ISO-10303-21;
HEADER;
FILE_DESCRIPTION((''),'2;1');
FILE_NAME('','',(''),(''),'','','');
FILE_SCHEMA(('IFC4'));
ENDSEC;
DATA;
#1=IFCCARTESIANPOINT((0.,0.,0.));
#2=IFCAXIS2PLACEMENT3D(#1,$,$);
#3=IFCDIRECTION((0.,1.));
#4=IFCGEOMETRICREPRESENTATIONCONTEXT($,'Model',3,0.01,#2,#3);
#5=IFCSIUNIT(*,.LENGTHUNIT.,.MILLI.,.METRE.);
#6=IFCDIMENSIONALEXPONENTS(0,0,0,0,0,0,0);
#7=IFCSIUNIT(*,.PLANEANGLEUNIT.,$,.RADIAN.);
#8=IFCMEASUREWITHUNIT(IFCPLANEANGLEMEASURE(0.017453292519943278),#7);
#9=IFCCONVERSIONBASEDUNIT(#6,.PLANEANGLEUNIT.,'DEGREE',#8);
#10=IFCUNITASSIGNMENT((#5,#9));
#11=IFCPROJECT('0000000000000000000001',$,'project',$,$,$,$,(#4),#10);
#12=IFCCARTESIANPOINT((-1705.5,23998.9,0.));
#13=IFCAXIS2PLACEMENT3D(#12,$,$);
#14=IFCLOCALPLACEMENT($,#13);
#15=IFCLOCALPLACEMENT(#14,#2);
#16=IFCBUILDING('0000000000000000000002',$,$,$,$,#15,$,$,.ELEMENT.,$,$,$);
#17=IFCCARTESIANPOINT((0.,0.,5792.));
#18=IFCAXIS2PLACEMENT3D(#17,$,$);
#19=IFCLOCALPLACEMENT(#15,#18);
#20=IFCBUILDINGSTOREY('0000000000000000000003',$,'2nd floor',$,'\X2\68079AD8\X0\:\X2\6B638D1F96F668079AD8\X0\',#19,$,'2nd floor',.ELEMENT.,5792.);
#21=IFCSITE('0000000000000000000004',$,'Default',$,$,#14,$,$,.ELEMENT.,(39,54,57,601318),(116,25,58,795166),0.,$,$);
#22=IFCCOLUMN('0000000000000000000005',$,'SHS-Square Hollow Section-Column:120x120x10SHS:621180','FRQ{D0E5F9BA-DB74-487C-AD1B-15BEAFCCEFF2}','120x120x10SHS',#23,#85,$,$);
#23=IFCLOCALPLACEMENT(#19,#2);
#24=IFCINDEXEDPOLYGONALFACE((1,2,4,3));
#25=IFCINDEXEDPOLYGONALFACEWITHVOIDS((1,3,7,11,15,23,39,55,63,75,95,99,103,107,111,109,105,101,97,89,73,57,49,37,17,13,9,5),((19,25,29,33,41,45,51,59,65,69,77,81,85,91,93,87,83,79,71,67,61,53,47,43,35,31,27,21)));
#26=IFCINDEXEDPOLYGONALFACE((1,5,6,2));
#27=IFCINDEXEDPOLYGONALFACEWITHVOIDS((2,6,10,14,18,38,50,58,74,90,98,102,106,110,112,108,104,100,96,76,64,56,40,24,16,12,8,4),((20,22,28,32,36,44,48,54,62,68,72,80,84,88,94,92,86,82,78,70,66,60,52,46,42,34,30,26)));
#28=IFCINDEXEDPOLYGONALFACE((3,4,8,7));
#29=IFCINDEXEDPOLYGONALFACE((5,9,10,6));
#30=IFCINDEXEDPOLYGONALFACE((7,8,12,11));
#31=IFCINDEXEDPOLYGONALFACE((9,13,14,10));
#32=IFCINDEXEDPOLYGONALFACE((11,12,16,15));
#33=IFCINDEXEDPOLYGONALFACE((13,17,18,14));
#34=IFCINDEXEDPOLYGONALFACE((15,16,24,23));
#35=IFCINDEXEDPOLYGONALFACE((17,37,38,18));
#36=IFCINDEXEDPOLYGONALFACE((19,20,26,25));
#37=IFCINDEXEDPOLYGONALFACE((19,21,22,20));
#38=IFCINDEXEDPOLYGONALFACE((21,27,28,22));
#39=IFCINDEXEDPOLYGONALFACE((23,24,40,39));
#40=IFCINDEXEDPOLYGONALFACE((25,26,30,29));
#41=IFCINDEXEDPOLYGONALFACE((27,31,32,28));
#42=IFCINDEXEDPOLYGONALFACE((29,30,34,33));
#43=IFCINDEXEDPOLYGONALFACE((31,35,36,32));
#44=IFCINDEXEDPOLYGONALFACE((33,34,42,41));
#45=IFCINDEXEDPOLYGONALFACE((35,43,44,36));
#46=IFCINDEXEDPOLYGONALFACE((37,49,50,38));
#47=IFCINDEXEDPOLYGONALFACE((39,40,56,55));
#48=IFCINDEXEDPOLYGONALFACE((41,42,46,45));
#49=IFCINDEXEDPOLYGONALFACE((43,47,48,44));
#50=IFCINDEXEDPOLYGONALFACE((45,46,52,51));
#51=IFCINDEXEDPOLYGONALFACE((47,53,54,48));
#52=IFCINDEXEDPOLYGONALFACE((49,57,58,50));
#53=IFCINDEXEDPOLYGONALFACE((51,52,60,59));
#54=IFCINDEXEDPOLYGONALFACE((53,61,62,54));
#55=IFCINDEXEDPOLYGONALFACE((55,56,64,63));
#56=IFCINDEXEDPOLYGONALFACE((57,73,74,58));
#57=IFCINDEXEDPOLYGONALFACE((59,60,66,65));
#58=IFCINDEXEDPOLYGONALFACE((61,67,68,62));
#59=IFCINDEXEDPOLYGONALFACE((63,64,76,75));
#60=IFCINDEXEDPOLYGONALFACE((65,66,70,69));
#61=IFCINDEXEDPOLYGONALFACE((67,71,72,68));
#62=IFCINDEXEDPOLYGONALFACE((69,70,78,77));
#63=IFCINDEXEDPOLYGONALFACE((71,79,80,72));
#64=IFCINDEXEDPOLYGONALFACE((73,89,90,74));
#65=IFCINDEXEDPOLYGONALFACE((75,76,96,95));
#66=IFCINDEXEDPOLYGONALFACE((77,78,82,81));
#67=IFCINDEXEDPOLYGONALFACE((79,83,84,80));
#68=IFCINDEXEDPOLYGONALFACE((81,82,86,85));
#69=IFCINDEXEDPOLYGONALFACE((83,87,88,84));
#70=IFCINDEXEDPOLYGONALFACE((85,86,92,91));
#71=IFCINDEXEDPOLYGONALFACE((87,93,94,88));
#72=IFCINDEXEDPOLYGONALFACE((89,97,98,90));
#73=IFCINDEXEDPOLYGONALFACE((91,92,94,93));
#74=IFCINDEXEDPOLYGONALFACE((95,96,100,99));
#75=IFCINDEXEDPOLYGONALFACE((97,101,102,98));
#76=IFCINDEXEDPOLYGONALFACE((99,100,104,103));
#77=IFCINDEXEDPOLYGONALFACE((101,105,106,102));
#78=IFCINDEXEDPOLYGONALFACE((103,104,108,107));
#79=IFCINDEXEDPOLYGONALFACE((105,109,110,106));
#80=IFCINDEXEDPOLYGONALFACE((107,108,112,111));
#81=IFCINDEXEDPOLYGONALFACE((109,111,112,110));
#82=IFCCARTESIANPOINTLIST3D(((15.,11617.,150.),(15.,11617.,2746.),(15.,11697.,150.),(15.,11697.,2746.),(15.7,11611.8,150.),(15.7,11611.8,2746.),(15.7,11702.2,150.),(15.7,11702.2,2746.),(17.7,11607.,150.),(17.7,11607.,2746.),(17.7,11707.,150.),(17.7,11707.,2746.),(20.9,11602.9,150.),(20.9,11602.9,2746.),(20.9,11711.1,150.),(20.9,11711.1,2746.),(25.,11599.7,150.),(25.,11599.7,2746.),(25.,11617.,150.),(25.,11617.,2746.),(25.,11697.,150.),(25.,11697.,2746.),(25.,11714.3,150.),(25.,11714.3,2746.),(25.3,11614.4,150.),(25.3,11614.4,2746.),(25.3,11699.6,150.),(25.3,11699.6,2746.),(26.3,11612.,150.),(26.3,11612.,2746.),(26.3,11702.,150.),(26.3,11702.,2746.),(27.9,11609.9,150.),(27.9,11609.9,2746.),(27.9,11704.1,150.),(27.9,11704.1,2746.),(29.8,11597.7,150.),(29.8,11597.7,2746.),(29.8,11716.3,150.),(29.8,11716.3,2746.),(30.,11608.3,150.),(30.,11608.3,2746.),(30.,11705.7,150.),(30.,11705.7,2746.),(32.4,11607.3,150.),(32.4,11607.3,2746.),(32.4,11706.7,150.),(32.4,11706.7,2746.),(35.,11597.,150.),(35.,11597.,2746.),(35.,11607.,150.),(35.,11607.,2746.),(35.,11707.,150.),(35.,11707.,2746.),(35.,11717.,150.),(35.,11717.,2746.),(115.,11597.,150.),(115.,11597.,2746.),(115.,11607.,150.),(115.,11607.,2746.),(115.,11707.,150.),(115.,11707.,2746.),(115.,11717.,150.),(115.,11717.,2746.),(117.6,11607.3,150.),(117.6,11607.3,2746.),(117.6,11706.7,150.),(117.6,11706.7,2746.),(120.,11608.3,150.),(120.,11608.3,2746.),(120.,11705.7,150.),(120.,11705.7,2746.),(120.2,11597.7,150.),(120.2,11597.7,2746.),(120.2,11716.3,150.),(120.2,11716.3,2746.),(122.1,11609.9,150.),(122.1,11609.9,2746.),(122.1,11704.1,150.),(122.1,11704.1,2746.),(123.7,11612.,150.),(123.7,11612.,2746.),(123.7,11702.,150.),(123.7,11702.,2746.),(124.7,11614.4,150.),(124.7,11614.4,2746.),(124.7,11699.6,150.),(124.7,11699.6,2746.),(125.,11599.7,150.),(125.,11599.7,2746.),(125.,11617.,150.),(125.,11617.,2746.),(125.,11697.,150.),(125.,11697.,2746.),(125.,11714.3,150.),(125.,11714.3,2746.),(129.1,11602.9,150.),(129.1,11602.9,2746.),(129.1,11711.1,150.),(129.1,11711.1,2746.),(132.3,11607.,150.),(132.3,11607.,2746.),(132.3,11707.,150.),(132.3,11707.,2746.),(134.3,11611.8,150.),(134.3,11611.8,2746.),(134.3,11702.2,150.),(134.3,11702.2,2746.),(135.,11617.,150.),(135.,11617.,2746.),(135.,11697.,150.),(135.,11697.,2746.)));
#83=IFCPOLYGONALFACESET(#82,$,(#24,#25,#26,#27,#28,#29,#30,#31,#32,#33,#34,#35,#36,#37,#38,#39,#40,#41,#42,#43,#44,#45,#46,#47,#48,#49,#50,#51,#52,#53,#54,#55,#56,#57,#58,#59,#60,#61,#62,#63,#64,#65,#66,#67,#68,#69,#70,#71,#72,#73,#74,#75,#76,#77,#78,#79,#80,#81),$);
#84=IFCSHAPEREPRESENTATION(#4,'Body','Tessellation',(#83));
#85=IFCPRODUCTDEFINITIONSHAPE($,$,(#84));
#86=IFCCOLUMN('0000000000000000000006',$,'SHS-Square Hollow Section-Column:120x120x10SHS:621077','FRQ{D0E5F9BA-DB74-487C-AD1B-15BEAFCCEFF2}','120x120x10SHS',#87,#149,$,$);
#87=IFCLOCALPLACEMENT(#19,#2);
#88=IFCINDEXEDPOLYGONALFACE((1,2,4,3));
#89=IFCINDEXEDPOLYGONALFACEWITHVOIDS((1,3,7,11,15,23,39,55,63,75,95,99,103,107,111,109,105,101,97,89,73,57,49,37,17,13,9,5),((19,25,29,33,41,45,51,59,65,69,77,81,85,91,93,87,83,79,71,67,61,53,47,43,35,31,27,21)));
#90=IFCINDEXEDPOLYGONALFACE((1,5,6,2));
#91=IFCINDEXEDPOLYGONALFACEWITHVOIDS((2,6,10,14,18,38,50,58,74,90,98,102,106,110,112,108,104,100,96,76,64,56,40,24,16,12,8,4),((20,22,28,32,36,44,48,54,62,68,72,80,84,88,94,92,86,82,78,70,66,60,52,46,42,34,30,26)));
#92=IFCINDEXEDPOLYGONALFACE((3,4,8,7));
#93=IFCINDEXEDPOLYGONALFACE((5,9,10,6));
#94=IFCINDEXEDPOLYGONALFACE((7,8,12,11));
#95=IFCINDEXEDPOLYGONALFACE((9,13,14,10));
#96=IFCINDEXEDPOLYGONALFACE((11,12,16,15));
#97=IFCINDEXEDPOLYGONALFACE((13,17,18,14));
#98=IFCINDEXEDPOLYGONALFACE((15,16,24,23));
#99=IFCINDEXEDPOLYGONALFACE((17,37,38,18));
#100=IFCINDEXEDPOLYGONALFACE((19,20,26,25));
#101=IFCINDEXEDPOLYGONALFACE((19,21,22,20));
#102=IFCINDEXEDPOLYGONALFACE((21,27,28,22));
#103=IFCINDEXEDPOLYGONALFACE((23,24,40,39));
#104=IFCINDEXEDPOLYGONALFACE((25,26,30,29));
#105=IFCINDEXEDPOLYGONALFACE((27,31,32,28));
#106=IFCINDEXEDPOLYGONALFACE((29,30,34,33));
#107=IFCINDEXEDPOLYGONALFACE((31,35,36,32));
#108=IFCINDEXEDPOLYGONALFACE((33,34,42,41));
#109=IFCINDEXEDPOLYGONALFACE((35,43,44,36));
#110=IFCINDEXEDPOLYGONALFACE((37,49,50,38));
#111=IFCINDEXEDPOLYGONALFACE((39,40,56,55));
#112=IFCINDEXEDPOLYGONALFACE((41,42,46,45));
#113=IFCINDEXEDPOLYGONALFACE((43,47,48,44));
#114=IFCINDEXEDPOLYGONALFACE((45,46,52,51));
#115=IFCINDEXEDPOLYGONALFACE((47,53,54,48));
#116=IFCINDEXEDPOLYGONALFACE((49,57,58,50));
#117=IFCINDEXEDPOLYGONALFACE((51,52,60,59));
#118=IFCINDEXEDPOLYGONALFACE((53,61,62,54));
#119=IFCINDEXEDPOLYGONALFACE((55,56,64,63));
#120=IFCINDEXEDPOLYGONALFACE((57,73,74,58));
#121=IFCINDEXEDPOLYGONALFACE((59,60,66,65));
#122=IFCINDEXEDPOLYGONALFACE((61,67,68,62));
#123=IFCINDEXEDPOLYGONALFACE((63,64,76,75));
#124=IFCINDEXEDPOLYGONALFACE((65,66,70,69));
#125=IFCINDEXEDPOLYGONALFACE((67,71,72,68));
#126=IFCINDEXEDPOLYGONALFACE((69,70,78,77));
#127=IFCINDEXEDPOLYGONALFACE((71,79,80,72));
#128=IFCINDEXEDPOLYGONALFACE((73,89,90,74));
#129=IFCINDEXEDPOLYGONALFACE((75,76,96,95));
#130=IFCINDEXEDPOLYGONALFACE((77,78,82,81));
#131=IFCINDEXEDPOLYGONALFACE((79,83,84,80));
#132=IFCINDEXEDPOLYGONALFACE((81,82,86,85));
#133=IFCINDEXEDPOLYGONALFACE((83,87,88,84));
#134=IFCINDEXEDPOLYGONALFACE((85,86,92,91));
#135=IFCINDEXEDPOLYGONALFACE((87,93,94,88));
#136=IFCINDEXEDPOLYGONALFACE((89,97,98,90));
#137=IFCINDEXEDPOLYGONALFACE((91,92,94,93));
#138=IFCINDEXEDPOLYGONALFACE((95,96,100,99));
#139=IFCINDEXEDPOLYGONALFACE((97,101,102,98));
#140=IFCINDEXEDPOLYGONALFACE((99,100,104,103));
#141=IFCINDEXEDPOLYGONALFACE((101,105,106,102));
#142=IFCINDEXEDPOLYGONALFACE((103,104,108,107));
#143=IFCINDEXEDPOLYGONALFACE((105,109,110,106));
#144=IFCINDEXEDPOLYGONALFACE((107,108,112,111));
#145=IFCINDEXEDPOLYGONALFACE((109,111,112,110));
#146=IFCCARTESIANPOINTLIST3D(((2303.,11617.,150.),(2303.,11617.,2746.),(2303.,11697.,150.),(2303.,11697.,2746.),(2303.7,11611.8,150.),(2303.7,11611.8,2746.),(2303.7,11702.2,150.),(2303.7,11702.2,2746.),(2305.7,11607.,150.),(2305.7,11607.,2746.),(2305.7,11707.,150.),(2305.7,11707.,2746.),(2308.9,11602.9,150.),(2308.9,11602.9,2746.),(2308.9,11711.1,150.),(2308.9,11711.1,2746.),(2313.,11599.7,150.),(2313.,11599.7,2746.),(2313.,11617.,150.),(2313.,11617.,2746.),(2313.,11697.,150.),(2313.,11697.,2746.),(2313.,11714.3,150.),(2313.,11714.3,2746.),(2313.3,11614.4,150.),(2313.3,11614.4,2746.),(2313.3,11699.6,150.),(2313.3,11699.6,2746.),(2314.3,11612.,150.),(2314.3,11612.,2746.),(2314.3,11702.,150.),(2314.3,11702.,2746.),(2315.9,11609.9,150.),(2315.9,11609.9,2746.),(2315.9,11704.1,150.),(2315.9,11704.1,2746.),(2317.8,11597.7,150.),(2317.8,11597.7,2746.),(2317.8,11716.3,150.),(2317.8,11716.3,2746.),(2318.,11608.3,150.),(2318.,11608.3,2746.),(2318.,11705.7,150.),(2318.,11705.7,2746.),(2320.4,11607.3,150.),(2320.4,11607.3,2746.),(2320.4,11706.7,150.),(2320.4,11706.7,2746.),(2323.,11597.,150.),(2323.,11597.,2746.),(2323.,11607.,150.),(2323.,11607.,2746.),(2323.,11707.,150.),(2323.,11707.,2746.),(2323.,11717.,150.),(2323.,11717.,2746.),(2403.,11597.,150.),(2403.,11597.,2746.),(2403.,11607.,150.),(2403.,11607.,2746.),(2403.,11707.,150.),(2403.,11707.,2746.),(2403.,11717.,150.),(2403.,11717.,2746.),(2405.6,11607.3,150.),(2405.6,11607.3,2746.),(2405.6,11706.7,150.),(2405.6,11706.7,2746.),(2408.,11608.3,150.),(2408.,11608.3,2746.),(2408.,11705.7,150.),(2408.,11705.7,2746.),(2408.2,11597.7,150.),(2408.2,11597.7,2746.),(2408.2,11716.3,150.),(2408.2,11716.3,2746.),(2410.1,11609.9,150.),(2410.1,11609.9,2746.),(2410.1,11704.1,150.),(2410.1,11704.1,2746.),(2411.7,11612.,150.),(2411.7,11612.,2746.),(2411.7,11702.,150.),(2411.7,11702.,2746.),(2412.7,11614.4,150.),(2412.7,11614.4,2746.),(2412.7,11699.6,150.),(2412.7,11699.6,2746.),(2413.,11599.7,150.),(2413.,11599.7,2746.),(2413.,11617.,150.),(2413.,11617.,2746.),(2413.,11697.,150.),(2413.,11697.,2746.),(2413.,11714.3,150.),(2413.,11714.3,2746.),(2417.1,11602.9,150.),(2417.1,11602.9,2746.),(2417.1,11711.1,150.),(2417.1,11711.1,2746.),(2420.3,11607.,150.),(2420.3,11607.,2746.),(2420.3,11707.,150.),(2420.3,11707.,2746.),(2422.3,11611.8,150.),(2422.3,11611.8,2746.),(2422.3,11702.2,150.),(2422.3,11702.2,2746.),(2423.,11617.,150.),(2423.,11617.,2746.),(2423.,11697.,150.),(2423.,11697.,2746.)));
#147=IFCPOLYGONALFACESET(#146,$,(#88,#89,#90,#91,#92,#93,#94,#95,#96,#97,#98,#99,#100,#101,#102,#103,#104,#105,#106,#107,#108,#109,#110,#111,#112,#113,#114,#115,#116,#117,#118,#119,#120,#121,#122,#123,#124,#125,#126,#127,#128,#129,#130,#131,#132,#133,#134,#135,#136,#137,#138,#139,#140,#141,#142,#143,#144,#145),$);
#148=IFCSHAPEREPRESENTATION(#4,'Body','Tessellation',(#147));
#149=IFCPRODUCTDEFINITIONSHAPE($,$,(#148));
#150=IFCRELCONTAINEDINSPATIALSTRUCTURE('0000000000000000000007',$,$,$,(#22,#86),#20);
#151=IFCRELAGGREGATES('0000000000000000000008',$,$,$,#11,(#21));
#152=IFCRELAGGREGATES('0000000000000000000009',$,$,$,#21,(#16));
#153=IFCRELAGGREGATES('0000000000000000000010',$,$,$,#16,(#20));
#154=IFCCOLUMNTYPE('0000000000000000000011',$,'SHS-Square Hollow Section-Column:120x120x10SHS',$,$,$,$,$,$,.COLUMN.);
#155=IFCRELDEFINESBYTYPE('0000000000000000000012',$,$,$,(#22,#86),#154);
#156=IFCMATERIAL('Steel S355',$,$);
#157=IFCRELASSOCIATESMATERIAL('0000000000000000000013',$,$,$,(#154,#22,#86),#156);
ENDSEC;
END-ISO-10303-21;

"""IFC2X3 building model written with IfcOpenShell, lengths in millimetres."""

from ifc_helpers import new_model, entity, si_unit, converted_unit, direction, frame, origin, origin_2d, place, context, project, spatial, hollow_rectangle, extrude, clip, halfspace, material, type_object, element, save


model = new_model("IFC2X3")

# Units and contexts
model_context = context("Model", 3, precision=0.01, world=origin(), true_north=direction((0.0, 1.0)))
ifc_project = project(units=[si_unit("LENGTHUNIT", "METRE", prefix="MILLI"), converted_unit("PLANEANGLEUNIT", "DEGREE", entity("IfcPlaneAngleMeasure", 0.017453292519943278), si_unit("PLANEANGLEUNIT", "RADIAN"), dimensions=[0, 0, 0, 0, 0, 0, 0])], contexts=[model_context])

# Site, building, storey
site_placement = place(None, frame((-1705.5, 23998.9, 0.0)))
site = spatial("IfcSite", under=ifc_project, at=site_placement, Name="Default", CompositionType="ELEMENT", RefLatitude=(39, 54, 57, 601318), RefLongitude=(116, 25, 58, 795166), RefElevation=0.0)
building_placement = place(site_placement, origin())
building = spatial("IfcBuilding", under=site, at=building_placement, CompositionType="ELEMENT")
storey_placement = place(building_placement, frame((0.0, 0.0, 5792.0)))
storey = spatial("IfcBuildingStorey", under=building, at=storey_placement, Name="2nd floor", ObjectType="标高:正负零标高", LongName="2nd floor", CompositionType="ELEMENT", Elevation=5792.0)

# Columns
ifc_material_1 = material(Name="Steel S355")
column_type_1 = type_object("IfcColumnType", Name="SHS-Square Hollow Section-Column:120x120x10SHS", PredefinedType="COLUMN", material=ifc_material_1)
column_1_placement = place(storey_placement, frame((75.0, 11657.0, 2830.9), z_axis=(0.0, 0.0, 1.0), x_axis=(0.0, -1.0, 0.0)))
element("IfcColumn", 1, at=column_1_placement, inside=storey, type_object=column_type_1, material=ifc_material_1, Name="SHS-Square Hollow Section-Column:120x120x10SHS:621180", Description="FRQ{D0E5F9BA-DB74-487C-AD1B-15BEAFCCEFF2}", ObjectType="120x120x10SHS", context=model_context, shape_type="Clipping", body=[
    clip(clip(extrude(hollow_rectangle(XDim=120.0, YDim=120.0, WallThickness=10.0, InnerFilletRadius=10.0, OuterFilletRadius=20.0, at=origin_2d()), origin(), (0.0, 0.0, -1.0), 2765.7), halfspace(frame((11657.0, -75.0, -84.9), z_axis=(0.0, 0.0, -1.0), x_axis=(0.0, -1.0, 0.0)), True)), halfspace(frame((11657.0, -75.0, -2680.9), z_axis=(0.0, 0.0, 1.0), x_axis=(0.0, 1.0, 0.0)), True)),
])
column_2_placement = place(storey_placement, frame((2363.0, 11657.0, 2830.9), z_axis=(0.0, 0.0, 1.0), x_axis=(0.0, -1.0, 0.0)))
element("IfcColumn", 2, at=column_2_placement, inside=storey, type_object=column_type_1, material=ifc_material_1, Name="SHS-Square Hollow Section-Column:120x120x10SHS:621077", Description="FRQ{D0E5F9BA-DB74-487C-AD1B-15BEAFCCEFF2}", ObjectType="120x120x10SHS", context=model_context, shape_type="Clipping", body=[
    clip(clip(extrude(hollow_rectangle(XDim=120.0, YDim=120.0, WallThickness=10.0, InnerFilletRadius=10.0, OuterFilletRadius=20.0, at=origin_2d()), origin(), (0.0, 0.0, -1.0), 2765.7), halfspace(frame((11657.0, -2363.0, -84.9), z_axis=(0.0, 0.0, -1.0), x_axis=(0.0, -1.0, 0.0)), True)), halfspace(frame((11657.0, -2363.0, -2680.9), z_axis=(0.0, 0.0, 1.0), x_axis=(0.0, 1.0, 0.0)), True)),
])

save(model, "model.ifc")
